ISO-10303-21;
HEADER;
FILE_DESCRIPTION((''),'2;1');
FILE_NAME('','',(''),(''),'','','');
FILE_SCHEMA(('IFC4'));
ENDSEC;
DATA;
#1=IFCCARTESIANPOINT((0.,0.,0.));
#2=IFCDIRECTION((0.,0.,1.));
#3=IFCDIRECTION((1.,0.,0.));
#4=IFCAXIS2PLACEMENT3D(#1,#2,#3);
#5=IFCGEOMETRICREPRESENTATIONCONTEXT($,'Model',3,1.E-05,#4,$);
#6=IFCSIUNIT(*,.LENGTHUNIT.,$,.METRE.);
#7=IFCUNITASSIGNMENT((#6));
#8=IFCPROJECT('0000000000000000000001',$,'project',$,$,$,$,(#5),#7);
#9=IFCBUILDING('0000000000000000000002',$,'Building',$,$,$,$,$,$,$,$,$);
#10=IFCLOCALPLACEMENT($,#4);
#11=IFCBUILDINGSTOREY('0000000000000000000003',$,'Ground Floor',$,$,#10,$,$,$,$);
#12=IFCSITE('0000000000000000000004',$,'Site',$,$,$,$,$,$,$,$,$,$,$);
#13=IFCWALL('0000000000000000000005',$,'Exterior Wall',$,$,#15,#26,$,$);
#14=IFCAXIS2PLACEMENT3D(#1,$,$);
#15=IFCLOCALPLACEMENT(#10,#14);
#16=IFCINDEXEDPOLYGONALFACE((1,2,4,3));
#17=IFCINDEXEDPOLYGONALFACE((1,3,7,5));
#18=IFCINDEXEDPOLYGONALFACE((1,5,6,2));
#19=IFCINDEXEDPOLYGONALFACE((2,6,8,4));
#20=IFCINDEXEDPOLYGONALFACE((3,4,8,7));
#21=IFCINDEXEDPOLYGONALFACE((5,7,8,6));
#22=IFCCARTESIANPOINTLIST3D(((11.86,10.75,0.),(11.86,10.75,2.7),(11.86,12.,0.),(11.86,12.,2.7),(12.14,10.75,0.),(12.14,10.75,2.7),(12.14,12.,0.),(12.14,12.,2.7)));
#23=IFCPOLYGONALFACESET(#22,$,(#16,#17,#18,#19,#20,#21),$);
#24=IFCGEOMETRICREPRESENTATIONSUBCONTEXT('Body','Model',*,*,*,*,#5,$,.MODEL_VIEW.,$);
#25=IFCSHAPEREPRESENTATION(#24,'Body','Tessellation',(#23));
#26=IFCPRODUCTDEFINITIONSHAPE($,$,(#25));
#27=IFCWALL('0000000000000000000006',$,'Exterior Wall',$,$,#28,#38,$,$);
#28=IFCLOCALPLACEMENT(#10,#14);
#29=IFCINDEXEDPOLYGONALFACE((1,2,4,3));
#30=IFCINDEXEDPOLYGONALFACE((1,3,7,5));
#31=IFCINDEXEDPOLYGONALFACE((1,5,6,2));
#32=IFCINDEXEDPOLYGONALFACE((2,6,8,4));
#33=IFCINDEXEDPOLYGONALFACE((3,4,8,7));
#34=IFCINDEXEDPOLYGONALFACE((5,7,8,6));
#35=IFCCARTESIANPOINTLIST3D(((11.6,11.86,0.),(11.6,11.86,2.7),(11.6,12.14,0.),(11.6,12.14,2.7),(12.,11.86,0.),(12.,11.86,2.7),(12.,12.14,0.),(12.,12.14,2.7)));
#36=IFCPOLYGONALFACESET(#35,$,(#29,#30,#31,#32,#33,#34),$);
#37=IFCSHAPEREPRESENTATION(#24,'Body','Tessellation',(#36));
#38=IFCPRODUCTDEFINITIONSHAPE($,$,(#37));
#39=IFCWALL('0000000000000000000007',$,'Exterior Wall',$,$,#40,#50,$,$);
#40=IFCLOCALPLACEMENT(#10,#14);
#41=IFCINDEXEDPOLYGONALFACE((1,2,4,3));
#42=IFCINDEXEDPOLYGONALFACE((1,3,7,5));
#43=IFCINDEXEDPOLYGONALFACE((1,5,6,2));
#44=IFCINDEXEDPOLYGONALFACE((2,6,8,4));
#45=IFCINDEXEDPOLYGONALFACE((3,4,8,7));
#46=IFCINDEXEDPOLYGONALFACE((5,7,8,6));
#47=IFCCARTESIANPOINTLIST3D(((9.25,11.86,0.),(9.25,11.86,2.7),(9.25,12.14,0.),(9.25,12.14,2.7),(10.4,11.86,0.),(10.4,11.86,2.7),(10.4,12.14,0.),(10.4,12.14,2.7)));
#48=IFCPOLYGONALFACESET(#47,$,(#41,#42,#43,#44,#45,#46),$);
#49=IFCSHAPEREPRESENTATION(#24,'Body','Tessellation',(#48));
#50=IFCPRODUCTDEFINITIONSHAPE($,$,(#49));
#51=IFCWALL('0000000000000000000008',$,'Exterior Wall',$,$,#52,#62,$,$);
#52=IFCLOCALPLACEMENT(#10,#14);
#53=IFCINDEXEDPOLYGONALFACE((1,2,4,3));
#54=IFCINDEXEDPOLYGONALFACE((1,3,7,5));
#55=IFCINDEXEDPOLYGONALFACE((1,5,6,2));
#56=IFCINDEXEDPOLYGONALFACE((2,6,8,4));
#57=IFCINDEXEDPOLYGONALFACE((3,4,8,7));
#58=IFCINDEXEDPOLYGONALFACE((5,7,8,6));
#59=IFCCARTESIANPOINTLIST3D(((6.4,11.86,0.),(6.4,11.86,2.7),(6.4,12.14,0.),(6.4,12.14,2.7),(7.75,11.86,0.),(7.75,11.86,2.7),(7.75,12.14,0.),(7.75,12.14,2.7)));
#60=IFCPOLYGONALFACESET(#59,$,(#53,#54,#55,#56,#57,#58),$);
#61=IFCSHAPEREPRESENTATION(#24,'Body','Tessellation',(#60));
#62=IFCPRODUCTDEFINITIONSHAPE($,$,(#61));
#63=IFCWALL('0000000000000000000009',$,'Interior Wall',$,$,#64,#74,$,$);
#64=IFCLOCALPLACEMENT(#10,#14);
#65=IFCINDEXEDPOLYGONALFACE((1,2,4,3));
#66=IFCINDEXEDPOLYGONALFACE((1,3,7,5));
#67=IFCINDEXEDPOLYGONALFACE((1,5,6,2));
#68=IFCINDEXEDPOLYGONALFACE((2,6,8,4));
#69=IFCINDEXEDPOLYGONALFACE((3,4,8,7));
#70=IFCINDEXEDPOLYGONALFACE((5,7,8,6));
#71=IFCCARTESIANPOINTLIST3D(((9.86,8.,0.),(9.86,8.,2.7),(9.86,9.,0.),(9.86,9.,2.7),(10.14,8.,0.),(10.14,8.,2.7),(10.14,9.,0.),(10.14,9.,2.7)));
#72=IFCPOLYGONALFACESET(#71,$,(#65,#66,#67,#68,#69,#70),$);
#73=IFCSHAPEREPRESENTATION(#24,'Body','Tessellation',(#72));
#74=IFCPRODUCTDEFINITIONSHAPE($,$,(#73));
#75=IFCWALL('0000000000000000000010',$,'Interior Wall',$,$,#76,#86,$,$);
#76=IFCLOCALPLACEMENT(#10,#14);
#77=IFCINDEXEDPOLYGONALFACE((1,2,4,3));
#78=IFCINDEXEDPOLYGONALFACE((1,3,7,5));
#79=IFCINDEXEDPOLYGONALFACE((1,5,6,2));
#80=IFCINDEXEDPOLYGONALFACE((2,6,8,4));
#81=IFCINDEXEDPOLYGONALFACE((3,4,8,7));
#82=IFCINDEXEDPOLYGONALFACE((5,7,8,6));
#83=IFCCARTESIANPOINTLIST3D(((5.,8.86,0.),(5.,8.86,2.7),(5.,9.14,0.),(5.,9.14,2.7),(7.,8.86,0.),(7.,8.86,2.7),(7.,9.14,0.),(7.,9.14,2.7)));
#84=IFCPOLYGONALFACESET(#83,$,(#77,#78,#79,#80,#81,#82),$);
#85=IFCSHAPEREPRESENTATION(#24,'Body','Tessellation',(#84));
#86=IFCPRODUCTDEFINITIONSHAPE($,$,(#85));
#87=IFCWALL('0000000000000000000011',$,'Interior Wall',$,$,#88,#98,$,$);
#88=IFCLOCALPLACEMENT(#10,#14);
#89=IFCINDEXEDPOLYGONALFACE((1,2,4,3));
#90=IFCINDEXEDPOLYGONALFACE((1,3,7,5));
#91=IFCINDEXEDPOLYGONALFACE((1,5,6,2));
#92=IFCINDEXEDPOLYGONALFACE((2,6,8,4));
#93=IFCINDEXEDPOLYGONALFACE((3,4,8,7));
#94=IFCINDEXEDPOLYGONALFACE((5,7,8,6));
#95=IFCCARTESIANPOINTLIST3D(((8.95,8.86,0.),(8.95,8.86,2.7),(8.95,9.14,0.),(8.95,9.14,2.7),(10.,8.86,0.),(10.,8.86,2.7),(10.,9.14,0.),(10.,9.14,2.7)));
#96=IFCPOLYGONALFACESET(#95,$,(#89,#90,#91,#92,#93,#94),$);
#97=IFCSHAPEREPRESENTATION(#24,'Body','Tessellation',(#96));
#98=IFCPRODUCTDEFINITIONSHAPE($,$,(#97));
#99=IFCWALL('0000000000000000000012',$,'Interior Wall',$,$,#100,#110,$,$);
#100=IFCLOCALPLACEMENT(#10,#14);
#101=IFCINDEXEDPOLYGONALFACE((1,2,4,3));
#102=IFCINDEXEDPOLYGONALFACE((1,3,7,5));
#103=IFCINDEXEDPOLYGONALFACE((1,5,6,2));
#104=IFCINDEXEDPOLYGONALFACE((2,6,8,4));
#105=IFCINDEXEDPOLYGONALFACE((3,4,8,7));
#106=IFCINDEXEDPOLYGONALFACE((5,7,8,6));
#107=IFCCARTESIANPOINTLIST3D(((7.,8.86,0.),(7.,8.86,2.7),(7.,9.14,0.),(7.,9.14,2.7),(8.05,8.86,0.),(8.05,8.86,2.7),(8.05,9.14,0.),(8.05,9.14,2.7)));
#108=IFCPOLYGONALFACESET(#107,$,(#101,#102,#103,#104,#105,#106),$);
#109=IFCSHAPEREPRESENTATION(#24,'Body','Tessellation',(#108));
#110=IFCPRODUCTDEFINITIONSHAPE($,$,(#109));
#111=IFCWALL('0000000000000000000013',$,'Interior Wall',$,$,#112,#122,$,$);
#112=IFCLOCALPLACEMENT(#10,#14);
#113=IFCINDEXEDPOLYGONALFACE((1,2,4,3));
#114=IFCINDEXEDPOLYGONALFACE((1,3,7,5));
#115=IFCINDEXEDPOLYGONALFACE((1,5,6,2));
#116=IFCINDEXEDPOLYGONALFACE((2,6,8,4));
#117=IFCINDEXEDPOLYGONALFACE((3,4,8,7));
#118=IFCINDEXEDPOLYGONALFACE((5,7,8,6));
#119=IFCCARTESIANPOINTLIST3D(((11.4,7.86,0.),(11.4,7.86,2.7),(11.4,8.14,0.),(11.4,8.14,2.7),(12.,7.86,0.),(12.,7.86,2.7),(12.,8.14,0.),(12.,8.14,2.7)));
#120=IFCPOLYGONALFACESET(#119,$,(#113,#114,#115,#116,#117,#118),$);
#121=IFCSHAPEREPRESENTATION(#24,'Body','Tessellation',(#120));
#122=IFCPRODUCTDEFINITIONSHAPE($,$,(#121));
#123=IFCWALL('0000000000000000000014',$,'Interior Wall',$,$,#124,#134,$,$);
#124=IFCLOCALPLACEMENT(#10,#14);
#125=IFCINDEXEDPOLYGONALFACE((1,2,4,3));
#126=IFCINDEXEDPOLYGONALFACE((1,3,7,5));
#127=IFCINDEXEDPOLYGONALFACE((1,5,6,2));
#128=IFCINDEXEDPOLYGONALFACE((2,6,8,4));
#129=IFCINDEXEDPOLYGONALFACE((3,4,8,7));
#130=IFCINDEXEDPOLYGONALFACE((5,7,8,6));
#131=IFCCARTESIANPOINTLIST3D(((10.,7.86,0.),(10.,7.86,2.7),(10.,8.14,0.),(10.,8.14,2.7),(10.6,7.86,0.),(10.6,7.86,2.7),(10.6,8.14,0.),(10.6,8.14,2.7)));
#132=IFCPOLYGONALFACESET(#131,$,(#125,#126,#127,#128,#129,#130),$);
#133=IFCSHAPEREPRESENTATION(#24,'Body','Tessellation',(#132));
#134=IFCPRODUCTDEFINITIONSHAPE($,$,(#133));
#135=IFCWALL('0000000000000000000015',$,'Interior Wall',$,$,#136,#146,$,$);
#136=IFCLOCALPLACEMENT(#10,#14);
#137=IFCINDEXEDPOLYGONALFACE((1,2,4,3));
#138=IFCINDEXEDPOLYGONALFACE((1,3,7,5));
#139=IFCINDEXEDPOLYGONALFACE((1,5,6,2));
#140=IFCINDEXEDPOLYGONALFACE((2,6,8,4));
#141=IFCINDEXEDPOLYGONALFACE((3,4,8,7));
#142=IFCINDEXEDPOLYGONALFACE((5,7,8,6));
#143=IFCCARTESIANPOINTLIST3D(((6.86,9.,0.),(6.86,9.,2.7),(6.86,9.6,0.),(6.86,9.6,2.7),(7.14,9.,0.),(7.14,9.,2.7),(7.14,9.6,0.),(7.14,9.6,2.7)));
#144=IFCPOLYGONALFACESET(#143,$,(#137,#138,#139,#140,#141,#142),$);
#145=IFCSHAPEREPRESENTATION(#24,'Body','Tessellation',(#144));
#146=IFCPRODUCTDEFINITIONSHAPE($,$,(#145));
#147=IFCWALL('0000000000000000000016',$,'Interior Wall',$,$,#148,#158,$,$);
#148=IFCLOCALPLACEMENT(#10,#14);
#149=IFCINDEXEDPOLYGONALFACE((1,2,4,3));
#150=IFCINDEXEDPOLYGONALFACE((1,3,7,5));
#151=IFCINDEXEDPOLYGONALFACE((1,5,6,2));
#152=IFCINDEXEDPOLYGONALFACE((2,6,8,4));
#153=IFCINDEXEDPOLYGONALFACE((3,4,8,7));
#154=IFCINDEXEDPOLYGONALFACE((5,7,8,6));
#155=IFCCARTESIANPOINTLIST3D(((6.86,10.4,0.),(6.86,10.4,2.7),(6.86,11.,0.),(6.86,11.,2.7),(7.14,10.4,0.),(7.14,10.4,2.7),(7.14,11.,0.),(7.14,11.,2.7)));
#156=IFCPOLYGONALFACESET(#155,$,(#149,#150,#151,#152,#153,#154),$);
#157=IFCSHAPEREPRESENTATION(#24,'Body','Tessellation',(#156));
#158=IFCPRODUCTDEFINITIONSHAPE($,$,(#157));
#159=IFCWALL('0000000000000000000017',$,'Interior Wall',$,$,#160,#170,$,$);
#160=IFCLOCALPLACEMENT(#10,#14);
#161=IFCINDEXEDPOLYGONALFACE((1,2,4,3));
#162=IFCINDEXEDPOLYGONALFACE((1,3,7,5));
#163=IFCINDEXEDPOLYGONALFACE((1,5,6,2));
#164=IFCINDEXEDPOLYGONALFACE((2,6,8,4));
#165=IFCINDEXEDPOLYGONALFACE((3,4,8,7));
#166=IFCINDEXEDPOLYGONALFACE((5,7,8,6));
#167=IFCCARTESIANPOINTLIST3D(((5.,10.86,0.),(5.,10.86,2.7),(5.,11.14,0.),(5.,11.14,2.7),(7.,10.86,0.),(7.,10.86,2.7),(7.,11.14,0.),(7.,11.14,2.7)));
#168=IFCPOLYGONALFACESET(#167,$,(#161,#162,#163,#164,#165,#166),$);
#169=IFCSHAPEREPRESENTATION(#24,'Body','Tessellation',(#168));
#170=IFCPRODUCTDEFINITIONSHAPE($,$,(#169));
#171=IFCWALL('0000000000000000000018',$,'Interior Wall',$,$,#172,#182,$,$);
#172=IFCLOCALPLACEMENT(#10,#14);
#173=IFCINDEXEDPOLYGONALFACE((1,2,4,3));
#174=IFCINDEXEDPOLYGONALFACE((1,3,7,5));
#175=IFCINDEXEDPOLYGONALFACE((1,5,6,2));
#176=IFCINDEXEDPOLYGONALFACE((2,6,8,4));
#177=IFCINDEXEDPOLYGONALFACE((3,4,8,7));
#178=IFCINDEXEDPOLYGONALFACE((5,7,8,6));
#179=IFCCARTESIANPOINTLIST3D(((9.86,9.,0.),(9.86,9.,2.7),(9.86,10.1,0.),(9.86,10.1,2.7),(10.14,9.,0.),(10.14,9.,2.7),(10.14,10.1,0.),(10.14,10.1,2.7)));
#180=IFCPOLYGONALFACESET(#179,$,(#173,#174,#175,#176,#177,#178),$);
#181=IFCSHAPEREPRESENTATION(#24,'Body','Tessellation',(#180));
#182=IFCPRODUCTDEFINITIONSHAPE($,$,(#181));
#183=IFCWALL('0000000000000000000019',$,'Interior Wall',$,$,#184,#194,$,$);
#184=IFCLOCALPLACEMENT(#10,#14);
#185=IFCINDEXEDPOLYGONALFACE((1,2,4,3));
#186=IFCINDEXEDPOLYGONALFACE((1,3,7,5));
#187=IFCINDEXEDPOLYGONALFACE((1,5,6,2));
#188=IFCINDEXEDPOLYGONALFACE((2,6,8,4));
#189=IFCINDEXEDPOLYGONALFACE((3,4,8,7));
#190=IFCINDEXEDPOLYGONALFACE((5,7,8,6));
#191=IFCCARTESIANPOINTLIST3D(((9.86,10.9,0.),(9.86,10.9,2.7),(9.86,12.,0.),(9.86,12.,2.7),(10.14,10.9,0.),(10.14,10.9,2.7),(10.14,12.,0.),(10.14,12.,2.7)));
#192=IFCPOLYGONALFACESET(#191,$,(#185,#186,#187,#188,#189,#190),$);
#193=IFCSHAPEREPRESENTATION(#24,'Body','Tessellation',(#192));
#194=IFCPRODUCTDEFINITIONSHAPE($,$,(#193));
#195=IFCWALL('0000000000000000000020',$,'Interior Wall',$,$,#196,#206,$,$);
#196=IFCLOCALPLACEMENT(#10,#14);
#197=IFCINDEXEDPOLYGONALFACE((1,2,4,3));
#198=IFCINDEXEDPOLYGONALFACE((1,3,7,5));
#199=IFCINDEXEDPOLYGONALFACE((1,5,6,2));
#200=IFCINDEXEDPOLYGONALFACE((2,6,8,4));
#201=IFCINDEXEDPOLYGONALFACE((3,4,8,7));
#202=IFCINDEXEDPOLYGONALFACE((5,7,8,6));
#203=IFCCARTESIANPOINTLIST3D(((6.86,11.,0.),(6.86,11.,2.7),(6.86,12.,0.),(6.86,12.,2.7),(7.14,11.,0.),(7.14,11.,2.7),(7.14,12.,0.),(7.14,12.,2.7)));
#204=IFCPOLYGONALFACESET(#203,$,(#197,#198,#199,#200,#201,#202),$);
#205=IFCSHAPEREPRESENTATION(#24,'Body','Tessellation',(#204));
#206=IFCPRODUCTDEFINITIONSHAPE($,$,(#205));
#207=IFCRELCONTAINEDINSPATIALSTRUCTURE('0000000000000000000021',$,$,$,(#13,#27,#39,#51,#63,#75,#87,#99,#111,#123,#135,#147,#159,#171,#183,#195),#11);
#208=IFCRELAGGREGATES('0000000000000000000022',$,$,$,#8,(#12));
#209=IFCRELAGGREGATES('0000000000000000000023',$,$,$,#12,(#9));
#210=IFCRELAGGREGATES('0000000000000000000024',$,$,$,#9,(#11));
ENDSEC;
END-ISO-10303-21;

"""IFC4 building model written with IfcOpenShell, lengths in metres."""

from ifc_helpers import new_model, si_unit, frame, origin_with_axes, place, context, subcontext, project, spatial, indexed_curve, outline, extrude, element, save


model = new_model("IFC4")

# Units and contexts
model_context = context("Model", 3, precision=1e-05, world=origin_with_axes())
body_context = subcontext(model_context, "Body", "Model", "MODEL_VIEW")
ifc_project = project(units=[si_unit("LENGTHUNIT", "METRE")], contexts=[model_context])

# Site, building, storey
site = spatial("IfcSite", under=ifc_project, Name="Site")
building = spatial("IfcBuilding", under=site, Name="Building")
storey_placement = place(None, origin_with_axes())
storey = spatial("IfcBuildingStorey", under=building, at=storey_placement, Name="Ground Floor")

# Walls
wall_1_placement = place(storey_placement, frame((12.0, 10.75, 0.0), z_axis=(0.0, 0.0, 1.0), x_axis=(0.0, 1.0, 0.0)))
element("IfcWall", 1, at=wall_1_placement, inside=storey, Name="Exterior Wall", context=body_context, shape_type="SweptSolid", body=[
    extrude(outline(indexed_curve([(0.0, 0.0), (0.0, 0.28), (1.25, 0.28), (1.25, 0.0), (0.0, 0.0)], self_intersect=False)), frame((0.0, -0.14, 0.0), z_axis=(0.0, 0.0, 1.0), x_axis=(1.0, 0.0, 0.0)), (0.0, 0.0, 1.0), 2.7),
])
wall_2_placement = place(storey_placement, frame((12.0, 12.0, 0.0), z_axis=(0.0, 0.0, 1.0), x_axis=(-1.0, 0.0, 0.0)))
element("IfcWall", 2, at=wall_2_placement, inside=storey, Name="Exterior Wall", context=body_context, shape_type="SweptSolid", body=[
    extrude(outline(indexed_curve([(0.0, 0.0), (0.0, 0.28), (0.4, 0.28), (0.4, 0.0), (0.0, 0.0)], self_intersect=False)), frame((0.0, -0.14, 0.0), z_axis=(0.0, 0.0, 1.0), x_axis=(1.0, 0.0, 0.0)), (0.0, 0.0, 1.0), 2.7),
])
wall_3_placement = place(storey_placement, frame((10.4, 12.0, 0.0), z_axis=(0.0, 0.0, 1.0), x_axis=(-1.0, 0.0, 0.0)))
element("IfcWall", 3, at=wall_3_placement, inside=storey, Name="Exterior Wall", context=body_context, shape_type="SweptSolid", body=[
    extrude(outline(indexed_curve([(0.0, 0.0), (0.0, 0.28), (1.15, 0.28), (1.15, 0.0), (0.0, 0.0)], self_intersect=False)), frame((0.0, -0.14, 0.0), z_axis=(0.0, 0.0, 1.0), x_axis=(1.0, 0.0, 0.0)), (0.0, 0.0, 1.0), 2.7),
])
wall_4_placement = place(storey_placement, frame((7.75, 12.0, 0.0), z_axis=(0.0, 0.0, 1.0), x_axis=(-1.0, 0.0, 0.0)))
element("IfcWall", 4, at=wall_4_placement, inside=storey, Name="Exterior Wall", context=body_context, shape_type="SweptSolid", body=[
    extrude(outline(indexed_curve([(0.0, 0.0), (0.0, 0.28), (1.35, 0.28), (1.35, 0.0), (0.0, 0.0)], self_intersect=False)), frame((0.0, -0.14, 0.0), z_axis=(0.0, 0.0, 1.0), x_axis=(1.0, 0.0, 0.0)), (0.0, 0.0, 1.0), 2.7),
])
wall_5_placement = place(storey_placement, frame((10.0, 8.0, 0.0), z_axis=(0.0, 0.0, 1.0), x_axis=(0.0, 1.0, 0.0)))
element("IfcWall", 5, at=wall_5_placement, inside=storey, Name="Interior Wall", context=body_context, shape_type="SweptSolid", body=[
    extrude(outline(indexed_curve([(0.0, 0.0), (0.0, 0.28), (1.0, 0.28), (1.0, 0.0), (0.0, 0.0)], self_intersect=False)), frame((0.0, -0.14, 0.0), z_axis=(0.0, 0.0, 1.0), x_axis=(1.0, 0.0, 0.0)), (0.0, 0.0, 1.0), 2.7),
])
wall_6_placement = place(storey_placement, frame((7.0, 9.0, 0.0), z_axis=(0.0, 0.0, 1.0), x_axis=(-1.0, 0.0, 0.0)))
element("IfcWall", 6, at=wall_6_placement, inside=storey, Name="Interior Wall", context=body_context, shape_type="SweptSolid", body=[
    extrude(outline(indexed_curve([(0.0, 0.0), (0.0, 0.28), (2.0, 0.28), (2.0, 0.0), (0.0, 0.0)], self_intersect=False)), frame((0.0, -0.14, 0.0), z_axis=(0.0, 0.0, 1.0), x_axis=(1.0, 0.0, 0.0)), (0.0, 0.0, 1.0), 2.7),
])
for number, where, z_axis, x_axis, name in (
    (7, (10.0, 9.0, 0.0), (0.0, 0.0, 1.0), (-1.0, 0.0, 0.0), "Interior Wall"),
    (8, (8.05, 9.0, 0.0), (0.0, 0.0, 1.0), (-1.0, 0.0, 0.0), "Interior Wall"),
):
    element("IfcWall", number, at=place(storey_placement, frame(where, z_axis=z_axis, x_axis=x_axis)), inside=storey, Name=name, context=body_context, shape_type="SweptSolid", body=[
        extrude(outline(indexed_curve([(0.0, 0.0), (0.0, 0.28), (1.05, 0.28), (1.05, 0.0), (0.0, 0.0)], self_intersect=False)), frame((0.0, -0.14, 0.0), z_axis=(0.0, 0.0, 1.0), x_axis=(1.0, 0.0, 0.0)), (0.0, 0.0, 1.0), 2.7),
    ])
for number, where, z_axis, x_axis, name in (
    (9, (12.0, 8.0, 0.0), (0.0, 0.0, 1.0), (-1.0, 0.0, 0.0), "Interior Wall"),
    (10, (10.6, 8.0, 0.0), (0.0, 0.0, 1.0), (-1.0, 0.0, 0.0), "Interior Wall"),
    (11, (7.0, 9.0, 0.0), (0.0, 0.0, 1.0), (0.0, 1.0, 0.0), "Interior Wall"),
    (12, (7.0, 10.4, 0.0), (0.0, 0.0, 1.0), (0.0, 1.0, 0.0), "Interior Wall"),
):
    element("IfcWall", number, at=place(storey_placement, frame(where, z_axis=z_axis, x_axis=x_axis)), inside=storey, Name=name, context=body_context, shape_type="SweptSolid", body=[
        extrude(outline(indexed_curve([(0.0, 0.0), (0.0, 0.28), (0.6, 0.28), (0.6, 0.0), (0.0, 0.0)], self_intersect=False)), frame((0.0, -0.14, 0.0), z_axis=(0.0, 0.0, 1.0), x_axis=(1.0, 0.0, 0.0)), (0.0, 0.0, 1.0), 2.7),
    ])
wall_7_placement = place(storey_placement, frame((7.0, 11.0, 0.0), z_axis=(0.0, 0.0, 1.0), x_axis=(-1.0, 0.0, 0.0)))
element("IfcWall", 13, at=wall_7_placement, inside=storey, Name="Interior Wall", context=body_context, shape_type="SweptSolid", body=[
    extrude(outline(indexed_curve([(0.0, 0.0), (0.0, 0.28), (2.0, 0.28), (2.0, 0.0), (0.0, 0.0)], self_intersect=False)), frame((0.0, -0.14, 0.0), z_axis=(0.0, 0.0, 1.0), x_axis=(1.0, 0.0, 0.0)), (0.0, 0.0, 1.0), 2.7),
])
for number, where, z_axis, x_axis, name in (
    (14, (10.0, 9.0, 0.0), (0.0, 0.0, 1.0), (0.0, 1.0, 0.0), "Interior Wall"),
    (15, (10.0, 10.9, 0.0), (0.0, 0.0, 1.0), (0.0, 1.0, 0.0), "Interior Wall"),
):
    element("IfcWall", number, at=place(storey_placement, frame(where, z_axis=z_axis, x_axis=x_axis)), inside=storey, Name=name, context=body_context, shape_type="SweptSolid", body=[
        extrude(outline(indexed_curve([(0.0, 0.0), (0.0, 0.28), (1.1, 0.28), (1.1, 0.0), (0.0, 0.0)], self_intersect=False)), frame((0.0, -0.14, 0.0), z_axis=(0.0, 0.0, 1.0), x_axis=(1.0, 0.0, 0.0)), (0.0, 0.0, 1.0), 2.7),
    ])
wall_8_placement = place(storey_placement, frame((7.0, 12.0, 0.0), z_axis=(0.0, 0.0, 1.0), x_axis=(0.0, -1.0, 0.0)))
element("IfcWall", 16, at=wall_8_placement, inside=storey, Name="Interior Wall", context=body_context, shape_type="SweptSolid", body=[
    extrude(outline(indexed_curve([(0.0, 0.0), (0.0, 0.28), (1.0, 0.28), (1.0, 0.0), (0.0, 0.0)], self_intersect=False)), frame((0.0, -0.14, 0.0), z_axis=(0.0, 0.0, 1.0), x_axis=(1.0, 0.0, 0.0)), (0.0, 0.0, 1.0), 2.7),
])

save(model, "model.ifc")
